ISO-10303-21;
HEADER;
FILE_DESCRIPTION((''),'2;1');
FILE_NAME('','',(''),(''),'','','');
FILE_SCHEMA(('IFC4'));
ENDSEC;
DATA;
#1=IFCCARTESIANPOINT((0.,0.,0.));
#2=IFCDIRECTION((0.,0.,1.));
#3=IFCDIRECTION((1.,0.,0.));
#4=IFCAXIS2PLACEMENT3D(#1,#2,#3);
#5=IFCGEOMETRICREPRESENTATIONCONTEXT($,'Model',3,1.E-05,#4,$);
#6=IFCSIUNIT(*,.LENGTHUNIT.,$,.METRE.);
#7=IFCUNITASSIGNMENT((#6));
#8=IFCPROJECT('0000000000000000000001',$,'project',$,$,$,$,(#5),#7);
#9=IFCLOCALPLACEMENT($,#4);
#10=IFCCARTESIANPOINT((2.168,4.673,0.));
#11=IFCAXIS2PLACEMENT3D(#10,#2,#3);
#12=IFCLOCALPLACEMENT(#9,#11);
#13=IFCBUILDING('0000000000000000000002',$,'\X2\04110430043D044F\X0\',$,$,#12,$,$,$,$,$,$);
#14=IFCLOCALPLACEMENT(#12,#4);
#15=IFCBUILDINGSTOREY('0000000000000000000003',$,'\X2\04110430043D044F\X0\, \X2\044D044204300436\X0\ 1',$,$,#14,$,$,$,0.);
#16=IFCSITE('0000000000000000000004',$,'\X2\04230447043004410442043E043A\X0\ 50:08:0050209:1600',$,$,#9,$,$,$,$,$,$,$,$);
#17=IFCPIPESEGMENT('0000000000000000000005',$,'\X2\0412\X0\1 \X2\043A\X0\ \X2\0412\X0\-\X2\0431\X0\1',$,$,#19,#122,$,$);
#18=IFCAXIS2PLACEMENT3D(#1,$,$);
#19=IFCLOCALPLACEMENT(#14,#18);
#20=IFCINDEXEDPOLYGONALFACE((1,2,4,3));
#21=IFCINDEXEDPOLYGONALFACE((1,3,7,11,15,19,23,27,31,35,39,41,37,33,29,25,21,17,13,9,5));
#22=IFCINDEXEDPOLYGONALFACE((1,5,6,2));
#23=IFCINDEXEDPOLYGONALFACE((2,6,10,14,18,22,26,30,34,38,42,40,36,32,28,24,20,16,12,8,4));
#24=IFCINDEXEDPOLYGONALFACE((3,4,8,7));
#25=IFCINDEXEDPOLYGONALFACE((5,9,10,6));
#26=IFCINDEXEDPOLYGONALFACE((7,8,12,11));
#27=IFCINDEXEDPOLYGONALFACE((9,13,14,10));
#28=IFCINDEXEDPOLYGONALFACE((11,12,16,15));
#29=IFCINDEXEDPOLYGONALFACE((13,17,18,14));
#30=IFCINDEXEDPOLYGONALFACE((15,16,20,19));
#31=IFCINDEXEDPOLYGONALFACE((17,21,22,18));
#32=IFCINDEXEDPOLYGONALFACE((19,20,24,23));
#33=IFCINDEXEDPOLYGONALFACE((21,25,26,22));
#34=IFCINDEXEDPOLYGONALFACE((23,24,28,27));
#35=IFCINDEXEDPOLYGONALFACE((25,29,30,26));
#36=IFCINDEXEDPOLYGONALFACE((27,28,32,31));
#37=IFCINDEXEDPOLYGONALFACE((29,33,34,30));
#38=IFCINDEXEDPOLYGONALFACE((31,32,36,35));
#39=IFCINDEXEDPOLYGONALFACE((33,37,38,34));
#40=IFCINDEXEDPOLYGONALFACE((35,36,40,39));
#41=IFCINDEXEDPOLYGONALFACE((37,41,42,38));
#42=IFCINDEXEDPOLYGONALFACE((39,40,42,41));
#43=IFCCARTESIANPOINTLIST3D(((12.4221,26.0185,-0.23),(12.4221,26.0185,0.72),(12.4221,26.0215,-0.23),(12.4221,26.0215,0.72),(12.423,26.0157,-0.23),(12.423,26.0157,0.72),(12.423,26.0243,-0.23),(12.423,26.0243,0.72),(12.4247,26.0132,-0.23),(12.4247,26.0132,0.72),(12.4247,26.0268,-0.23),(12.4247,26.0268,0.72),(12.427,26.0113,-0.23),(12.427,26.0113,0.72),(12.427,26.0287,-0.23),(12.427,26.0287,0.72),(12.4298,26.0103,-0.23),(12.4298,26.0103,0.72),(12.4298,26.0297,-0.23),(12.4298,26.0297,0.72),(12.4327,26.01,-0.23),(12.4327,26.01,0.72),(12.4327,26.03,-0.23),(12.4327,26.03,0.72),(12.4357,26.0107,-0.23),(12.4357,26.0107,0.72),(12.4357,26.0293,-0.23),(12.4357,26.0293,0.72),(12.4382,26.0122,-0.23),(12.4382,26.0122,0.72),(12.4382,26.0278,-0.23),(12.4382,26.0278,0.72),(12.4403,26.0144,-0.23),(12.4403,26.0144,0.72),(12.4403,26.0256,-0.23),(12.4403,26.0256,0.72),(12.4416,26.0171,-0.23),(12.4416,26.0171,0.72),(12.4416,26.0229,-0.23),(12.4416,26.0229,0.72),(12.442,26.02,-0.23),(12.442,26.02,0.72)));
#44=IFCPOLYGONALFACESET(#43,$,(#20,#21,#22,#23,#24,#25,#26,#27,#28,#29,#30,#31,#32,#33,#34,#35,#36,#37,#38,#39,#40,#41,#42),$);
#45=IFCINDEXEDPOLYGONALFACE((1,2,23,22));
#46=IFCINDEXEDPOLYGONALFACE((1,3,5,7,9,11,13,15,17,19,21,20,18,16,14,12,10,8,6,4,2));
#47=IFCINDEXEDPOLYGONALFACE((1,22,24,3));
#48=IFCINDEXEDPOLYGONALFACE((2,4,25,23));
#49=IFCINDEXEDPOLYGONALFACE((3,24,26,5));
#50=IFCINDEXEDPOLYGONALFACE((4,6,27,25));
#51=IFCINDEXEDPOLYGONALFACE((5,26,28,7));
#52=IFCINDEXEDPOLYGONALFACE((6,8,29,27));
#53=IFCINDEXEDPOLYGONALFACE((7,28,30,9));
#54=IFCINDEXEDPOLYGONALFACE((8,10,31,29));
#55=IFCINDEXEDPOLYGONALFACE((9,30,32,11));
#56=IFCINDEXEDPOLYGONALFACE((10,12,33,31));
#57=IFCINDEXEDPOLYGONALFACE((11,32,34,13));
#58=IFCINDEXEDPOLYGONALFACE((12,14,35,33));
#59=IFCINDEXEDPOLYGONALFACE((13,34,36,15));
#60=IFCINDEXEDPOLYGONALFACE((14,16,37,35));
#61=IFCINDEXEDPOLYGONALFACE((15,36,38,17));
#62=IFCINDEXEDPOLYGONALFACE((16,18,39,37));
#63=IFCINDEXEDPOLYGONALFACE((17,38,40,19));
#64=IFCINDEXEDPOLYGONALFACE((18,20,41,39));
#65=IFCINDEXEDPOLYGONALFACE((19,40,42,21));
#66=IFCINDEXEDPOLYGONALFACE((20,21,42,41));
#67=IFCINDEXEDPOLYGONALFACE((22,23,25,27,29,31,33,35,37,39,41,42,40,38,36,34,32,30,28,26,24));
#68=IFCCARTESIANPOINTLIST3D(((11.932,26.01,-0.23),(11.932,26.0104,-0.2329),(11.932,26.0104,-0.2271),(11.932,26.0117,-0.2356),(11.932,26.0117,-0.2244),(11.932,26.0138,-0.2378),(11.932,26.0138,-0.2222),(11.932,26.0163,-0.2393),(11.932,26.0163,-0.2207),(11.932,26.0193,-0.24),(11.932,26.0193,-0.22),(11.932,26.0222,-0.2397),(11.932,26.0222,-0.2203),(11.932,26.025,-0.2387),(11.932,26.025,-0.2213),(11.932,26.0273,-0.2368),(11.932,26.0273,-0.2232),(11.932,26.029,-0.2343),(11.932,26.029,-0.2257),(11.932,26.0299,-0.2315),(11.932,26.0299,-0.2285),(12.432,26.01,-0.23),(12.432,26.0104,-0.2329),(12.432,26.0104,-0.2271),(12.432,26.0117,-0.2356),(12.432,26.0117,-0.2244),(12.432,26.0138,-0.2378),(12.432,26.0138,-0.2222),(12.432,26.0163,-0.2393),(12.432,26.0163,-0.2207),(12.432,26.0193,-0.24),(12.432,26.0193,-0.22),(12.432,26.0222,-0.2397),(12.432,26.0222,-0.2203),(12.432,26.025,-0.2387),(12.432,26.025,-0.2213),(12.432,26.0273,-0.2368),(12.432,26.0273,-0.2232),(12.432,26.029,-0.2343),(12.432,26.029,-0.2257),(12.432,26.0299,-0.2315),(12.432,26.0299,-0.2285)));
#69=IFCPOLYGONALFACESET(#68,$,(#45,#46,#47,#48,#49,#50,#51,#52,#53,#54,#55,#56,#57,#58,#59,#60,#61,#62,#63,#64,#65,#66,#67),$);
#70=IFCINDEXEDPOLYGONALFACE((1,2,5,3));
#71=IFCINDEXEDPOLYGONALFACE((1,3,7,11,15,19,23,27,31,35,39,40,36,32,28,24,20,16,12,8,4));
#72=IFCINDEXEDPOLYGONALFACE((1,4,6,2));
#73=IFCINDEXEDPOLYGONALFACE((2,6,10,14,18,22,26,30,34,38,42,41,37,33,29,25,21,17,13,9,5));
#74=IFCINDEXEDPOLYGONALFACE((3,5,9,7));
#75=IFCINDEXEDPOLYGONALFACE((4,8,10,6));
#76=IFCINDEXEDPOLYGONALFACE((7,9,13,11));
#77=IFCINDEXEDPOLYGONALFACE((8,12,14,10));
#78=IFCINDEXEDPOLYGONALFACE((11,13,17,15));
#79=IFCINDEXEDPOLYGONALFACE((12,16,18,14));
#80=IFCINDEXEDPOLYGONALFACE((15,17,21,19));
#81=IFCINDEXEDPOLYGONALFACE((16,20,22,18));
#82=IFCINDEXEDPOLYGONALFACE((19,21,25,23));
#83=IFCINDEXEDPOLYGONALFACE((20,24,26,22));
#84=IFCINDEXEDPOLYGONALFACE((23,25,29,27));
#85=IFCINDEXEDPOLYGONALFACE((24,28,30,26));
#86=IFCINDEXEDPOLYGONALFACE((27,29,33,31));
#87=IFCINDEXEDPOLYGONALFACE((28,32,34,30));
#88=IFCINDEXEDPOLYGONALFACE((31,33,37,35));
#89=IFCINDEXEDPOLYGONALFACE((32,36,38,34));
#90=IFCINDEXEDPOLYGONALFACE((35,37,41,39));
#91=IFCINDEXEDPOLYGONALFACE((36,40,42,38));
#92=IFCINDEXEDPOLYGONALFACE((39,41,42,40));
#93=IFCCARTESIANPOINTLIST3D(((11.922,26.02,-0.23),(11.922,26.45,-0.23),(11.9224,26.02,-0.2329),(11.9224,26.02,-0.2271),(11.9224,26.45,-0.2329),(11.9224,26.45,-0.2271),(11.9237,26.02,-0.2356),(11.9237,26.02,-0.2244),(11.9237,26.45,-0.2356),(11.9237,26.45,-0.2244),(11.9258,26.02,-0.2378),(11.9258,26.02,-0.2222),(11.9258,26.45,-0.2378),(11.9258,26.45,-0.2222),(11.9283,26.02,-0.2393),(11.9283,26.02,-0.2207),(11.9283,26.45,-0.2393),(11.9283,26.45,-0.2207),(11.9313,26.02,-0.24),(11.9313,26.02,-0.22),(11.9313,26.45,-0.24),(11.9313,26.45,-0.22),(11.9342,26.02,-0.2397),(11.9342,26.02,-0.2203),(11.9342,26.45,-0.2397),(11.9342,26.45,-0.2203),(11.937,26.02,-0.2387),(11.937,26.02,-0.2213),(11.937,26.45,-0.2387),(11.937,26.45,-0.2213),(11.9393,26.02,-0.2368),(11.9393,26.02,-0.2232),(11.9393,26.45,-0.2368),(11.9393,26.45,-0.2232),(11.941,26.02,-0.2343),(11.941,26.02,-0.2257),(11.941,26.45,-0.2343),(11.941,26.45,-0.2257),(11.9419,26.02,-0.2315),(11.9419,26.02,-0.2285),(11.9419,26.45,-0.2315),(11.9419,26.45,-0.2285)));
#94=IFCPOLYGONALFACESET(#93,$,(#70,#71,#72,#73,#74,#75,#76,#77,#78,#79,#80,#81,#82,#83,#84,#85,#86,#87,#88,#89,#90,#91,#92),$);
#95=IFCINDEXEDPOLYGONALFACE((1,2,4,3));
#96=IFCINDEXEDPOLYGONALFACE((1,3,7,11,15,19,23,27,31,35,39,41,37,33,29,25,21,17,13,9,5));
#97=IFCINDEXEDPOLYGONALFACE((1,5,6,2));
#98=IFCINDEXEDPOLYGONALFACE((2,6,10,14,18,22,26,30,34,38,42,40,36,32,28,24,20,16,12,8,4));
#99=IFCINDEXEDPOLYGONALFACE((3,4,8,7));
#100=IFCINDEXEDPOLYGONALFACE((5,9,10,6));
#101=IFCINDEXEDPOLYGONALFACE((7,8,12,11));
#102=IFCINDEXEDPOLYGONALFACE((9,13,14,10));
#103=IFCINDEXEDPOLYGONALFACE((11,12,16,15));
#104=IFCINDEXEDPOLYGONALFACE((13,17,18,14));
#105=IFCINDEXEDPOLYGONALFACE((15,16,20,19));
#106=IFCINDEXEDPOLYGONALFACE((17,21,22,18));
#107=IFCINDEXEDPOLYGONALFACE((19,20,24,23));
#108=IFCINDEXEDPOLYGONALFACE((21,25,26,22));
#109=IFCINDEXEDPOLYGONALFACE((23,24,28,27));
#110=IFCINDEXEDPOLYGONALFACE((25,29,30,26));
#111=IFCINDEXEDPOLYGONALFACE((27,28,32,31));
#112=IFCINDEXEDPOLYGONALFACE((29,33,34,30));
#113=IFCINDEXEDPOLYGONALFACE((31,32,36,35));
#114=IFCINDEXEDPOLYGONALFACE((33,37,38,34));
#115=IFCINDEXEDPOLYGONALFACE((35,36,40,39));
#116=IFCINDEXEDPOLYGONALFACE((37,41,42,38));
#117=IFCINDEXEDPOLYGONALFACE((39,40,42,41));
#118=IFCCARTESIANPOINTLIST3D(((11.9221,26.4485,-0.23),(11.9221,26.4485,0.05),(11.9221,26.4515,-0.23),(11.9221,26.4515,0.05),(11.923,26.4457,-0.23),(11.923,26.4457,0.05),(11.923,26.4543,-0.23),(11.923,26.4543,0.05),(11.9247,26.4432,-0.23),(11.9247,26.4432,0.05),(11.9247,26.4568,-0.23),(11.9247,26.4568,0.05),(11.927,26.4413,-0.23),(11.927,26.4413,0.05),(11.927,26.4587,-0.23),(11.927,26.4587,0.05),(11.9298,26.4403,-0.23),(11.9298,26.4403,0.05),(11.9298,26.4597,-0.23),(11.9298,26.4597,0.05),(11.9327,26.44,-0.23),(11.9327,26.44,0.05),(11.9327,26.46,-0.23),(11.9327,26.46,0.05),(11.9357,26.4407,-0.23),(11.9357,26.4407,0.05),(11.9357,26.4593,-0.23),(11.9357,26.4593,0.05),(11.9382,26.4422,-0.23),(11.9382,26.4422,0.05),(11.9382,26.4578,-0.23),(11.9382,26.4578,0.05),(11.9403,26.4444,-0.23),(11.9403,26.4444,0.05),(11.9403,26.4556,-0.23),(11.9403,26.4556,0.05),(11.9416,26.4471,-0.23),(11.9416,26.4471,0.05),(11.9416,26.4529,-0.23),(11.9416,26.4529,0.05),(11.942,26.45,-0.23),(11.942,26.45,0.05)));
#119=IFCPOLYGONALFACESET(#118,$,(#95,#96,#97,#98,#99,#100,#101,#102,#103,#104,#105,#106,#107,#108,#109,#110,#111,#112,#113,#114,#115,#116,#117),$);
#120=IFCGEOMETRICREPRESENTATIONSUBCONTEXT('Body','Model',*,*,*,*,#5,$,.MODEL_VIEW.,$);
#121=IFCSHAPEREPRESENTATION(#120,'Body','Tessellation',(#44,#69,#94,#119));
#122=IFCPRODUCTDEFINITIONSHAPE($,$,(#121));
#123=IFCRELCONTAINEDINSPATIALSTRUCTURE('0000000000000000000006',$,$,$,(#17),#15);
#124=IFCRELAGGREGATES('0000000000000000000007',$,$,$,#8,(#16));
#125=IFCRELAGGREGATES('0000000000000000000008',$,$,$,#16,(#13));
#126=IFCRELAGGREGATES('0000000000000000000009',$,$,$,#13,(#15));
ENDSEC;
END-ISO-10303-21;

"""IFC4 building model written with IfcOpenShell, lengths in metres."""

from ifc_helpers import new_model, si_unit, frame, origin_with_axes, origin_2d, place, context, subcontext, project, spatial, circle, extrude, element, save


model = new_model("IFC4")

# Units and contexts
model_context = context("Model", 3, precision=1e-05, world=origin_with_axes())
body_context = subcontext(model_context, "Body", "Model", "MODEL_VIEW")
ifc_project = project(units=[si_unit("LENGTHUNIT", "METRE")], contexts=[model_context])

# Site, building, storey
site_placement = place(None, origin_with_axes())
site = spatial("IfcSite", under=ifc_project, at=site_placement, Name="Участок 50:08:0050209:1600")
building_placement = place(site_placement, frame((2.168, 4.673, 0.0), z_axis=(0.0, 0.0, 1.0), x_axis=(1.0, 0.0, 0.0)))
building = spatial("IfcBuilding", under=site, at=building_placement, Name="Баня")
storey_placement = place(building_placement, origin_with_axes())
storey = spatial("IfcBuildingStorey", under=building, at=storey_placement, Name="Баня, этаж 1", Elevation=0.0)

# Pipe segment
pipe_segment_1_placement = place(storey_placement, origin_with_axes())
element("IfcPipeSegment", 1, at=pipe_segment_1_placement, inside=storey, Name="В1 к В-б1", context=body_context, shape_type="SweptSolid", body=[
    extrude(circle(Radius=0.01, at=origin_2d()), frame((12.432, 26.02, 0.72), z_axis=(0.0, 0.0, -1.0), x_axis=(1.0, 0.0, 0.0)), (0.0, 0.0, 1.0), 0.95),
    extrude(circle(Radius=0.01, at=origin_2d()), frame((12.432, 26.02, -0.23), z_axis=(-1.0, 0.0, 0.0), x_axis=(0.0, -1.0, 0.0)), (0.0, 0.0, 1.0), 0.5),
    extrude(circle(Radius=0.01, at=origin_2d()), frame((11.932, 26.02, -0.23), z_axis=(0.0, 1.0, 0.0), x_axis=(-1.0, 0.0, 0.0)), (0.0, 0.0, 1.0), 0.43),
    extrude(circle(Radius=0.01, at=origin_2d()), frame((11.932, 26.45, -0.23), z_axis=(0.0, 0.0, 1.0), x_axis=(1.0, 0.0, 0.0)), (0.0, 0.0, 1.0), 0.28),
])

save(model, "model.ifc")
